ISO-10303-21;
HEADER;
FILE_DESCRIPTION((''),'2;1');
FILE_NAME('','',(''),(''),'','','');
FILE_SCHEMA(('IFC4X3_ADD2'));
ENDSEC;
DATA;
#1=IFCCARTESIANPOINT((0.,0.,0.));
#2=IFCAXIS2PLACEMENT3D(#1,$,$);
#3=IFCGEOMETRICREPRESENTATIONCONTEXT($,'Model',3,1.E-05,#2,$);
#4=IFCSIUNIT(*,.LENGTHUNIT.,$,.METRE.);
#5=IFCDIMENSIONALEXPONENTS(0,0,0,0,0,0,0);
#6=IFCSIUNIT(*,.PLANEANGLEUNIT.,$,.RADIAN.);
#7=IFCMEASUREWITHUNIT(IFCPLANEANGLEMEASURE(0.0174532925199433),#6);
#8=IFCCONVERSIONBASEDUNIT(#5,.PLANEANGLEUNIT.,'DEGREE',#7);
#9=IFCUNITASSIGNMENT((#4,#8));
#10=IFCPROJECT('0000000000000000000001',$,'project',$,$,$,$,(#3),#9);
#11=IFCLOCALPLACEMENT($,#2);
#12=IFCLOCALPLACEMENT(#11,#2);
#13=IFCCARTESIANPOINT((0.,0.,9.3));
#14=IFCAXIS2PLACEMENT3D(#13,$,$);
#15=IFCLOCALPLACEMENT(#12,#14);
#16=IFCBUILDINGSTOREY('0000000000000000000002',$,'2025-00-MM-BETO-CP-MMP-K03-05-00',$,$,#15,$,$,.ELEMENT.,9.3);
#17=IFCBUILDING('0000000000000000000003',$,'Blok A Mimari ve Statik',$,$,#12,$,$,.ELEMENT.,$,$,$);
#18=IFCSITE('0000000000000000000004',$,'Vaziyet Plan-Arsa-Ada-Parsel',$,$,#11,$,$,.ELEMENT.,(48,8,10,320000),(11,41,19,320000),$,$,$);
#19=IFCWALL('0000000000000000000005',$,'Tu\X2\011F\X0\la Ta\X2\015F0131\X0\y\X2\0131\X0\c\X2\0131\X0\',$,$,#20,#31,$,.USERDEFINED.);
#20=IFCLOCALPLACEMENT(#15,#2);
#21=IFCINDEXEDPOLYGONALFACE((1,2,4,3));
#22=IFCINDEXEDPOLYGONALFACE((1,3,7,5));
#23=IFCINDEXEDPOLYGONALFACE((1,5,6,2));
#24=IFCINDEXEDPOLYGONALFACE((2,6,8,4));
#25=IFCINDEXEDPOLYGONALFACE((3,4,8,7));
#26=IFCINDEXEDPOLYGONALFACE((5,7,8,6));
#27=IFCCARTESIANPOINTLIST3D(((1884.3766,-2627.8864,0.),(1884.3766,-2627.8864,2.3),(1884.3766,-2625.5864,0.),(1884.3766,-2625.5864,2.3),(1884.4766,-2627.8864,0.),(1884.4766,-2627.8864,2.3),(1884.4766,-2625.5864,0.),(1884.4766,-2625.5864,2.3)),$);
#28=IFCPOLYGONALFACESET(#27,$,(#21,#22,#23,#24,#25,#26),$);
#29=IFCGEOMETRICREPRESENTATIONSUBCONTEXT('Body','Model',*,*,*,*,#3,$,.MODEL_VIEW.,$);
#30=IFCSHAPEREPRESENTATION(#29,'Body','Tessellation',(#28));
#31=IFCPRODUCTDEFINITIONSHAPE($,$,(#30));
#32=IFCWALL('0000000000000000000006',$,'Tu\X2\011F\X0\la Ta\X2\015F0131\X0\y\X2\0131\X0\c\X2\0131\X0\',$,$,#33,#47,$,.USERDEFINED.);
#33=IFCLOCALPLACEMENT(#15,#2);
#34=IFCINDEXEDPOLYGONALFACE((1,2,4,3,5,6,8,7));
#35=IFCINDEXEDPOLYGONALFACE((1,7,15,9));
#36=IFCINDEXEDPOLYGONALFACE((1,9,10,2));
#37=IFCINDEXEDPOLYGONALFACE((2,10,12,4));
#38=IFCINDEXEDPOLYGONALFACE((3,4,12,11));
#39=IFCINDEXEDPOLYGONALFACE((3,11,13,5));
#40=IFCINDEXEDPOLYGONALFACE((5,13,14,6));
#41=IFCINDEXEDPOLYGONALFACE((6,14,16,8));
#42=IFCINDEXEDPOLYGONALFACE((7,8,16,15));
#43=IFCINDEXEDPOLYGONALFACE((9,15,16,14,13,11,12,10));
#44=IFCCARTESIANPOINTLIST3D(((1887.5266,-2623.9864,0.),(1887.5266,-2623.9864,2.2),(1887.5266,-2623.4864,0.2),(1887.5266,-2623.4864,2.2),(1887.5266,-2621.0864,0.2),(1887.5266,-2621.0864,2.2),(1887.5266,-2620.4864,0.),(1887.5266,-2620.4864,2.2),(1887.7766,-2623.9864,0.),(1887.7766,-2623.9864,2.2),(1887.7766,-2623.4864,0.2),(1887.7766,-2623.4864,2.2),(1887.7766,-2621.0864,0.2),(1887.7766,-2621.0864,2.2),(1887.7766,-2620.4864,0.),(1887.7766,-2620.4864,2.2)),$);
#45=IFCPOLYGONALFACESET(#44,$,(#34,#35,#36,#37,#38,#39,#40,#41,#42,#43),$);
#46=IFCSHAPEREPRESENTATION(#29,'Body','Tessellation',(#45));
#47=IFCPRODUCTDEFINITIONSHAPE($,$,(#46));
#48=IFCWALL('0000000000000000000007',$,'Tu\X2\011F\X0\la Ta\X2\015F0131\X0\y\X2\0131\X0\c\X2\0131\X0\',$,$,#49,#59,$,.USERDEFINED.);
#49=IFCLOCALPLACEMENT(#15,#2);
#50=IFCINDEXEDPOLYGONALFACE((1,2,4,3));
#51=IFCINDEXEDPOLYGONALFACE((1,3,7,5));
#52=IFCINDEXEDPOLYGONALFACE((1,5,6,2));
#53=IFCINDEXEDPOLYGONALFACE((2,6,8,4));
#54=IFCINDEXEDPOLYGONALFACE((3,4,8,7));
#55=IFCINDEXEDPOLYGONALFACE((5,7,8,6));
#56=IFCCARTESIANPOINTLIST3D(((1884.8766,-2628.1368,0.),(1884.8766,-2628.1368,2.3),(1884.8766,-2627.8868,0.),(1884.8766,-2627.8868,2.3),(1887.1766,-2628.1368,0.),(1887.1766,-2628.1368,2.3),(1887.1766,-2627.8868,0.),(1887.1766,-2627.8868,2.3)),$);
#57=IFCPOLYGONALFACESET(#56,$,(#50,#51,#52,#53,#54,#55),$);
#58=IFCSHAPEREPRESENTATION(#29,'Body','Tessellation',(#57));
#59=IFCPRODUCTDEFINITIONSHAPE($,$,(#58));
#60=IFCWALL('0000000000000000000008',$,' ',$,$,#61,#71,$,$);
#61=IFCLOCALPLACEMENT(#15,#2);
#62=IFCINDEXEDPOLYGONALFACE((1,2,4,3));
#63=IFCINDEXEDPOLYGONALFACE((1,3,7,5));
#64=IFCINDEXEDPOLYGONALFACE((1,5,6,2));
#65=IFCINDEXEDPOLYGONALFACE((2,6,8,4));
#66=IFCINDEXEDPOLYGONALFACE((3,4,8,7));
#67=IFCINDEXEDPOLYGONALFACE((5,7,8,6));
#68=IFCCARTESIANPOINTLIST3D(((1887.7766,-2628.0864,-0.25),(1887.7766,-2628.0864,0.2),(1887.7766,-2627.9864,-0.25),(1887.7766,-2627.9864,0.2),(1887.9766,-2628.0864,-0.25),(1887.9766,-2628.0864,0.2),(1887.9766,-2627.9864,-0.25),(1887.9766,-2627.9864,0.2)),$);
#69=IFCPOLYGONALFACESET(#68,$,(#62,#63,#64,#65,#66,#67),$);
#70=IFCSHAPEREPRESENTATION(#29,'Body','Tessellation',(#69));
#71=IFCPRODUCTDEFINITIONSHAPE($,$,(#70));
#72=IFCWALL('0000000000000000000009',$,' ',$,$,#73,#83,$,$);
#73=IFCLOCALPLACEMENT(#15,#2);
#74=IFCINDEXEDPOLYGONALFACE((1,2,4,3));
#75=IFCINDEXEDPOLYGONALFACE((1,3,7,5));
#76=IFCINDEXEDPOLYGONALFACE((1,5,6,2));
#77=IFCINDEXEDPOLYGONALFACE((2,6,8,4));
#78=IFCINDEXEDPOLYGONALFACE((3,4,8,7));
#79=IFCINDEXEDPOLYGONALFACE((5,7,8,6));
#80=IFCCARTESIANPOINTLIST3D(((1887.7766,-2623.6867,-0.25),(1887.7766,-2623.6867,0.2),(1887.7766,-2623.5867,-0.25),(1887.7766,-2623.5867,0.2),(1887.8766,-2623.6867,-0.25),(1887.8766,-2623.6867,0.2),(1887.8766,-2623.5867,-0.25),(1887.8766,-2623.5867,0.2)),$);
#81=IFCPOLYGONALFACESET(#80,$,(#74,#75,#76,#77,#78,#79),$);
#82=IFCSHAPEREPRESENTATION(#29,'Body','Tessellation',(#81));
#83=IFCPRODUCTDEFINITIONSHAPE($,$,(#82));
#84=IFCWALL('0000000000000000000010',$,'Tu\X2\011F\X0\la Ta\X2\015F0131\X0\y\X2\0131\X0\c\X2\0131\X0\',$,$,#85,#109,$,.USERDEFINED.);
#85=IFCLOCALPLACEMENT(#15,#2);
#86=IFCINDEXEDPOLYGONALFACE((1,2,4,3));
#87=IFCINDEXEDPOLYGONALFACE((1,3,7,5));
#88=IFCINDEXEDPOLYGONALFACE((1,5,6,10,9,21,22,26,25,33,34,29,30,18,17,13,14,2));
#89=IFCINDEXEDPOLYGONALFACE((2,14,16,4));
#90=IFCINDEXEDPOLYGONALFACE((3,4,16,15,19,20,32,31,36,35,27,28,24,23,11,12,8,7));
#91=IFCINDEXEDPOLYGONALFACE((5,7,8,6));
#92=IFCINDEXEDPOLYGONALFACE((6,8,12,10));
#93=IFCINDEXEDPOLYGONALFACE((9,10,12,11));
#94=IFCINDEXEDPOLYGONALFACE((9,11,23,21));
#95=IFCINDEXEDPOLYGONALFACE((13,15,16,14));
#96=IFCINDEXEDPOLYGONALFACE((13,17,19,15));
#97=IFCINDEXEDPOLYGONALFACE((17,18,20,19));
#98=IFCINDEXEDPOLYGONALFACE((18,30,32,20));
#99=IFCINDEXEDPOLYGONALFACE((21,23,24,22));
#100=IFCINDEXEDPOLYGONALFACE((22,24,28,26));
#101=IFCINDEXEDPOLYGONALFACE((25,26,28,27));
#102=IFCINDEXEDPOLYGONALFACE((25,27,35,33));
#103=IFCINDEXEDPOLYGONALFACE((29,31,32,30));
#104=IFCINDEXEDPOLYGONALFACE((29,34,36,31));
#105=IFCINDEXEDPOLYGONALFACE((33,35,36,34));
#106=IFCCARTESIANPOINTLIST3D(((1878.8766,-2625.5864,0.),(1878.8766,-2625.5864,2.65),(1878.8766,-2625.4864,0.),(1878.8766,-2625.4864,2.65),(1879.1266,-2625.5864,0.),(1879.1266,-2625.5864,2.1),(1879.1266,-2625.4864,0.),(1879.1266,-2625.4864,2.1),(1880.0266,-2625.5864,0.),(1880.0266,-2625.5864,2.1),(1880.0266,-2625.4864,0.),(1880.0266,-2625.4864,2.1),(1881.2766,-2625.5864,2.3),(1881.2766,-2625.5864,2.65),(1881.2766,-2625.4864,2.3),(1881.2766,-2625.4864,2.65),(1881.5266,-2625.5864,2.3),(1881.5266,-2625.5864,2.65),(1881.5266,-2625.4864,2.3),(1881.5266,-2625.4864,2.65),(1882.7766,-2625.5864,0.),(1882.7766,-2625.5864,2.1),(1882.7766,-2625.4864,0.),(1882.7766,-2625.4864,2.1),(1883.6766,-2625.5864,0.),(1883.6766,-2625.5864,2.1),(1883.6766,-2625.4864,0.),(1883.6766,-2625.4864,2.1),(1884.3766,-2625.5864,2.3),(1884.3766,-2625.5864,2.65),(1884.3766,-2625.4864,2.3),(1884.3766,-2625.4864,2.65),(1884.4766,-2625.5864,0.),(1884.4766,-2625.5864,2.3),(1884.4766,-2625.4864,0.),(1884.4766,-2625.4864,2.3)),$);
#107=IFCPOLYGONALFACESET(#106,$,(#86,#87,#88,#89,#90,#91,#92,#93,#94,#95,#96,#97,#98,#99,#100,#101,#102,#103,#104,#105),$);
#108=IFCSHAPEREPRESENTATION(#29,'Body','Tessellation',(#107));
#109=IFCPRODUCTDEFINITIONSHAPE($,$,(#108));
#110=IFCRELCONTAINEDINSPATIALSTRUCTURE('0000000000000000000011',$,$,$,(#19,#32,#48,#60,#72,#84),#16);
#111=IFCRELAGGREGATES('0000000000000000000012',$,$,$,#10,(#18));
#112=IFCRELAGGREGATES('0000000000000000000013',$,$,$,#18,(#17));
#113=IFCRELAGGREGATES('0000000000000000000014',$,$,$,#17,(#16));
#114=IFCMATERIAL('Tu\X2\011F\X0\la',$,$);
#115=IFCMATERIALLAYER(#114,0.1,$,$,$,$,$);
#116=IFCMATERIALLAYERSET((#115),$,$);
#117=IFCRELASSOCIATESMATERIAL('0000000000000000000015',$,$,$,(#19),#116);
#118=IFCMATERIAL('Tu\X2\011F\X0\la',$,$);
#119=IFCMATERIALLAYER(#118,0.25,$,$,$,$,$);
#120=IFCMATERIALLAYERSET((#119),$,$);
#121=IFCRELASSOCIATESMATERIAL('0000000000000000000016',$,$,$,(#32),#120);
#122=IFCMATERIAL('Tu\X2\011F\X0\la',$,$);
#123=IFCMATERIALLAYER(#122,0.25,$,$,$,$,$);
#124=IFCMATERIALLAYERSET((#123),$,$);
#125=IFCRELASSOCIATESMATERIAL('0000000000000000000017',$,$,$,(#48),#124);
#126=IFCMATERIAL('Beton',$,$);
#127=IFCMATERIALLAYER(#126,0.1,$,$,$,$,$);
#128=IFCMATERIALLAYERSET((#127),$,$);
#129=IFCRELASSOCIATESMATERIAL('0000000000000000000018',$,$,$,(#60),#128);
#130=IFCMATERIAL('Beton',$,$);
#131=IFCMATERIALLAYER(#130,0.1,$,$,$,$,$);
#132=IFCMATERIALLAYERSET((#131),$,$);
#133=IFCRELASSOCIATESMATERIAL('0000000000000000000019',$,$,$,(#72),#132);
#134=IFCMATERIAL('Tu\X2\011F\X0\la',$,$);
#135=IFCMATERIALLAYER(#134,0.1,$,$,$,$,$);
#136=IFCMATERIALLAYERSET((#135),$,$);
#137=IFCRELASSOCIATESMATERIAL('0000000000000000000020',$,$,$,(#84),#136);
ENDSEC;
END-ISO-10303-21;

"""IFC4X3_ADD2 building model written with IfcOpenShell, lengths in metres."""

from ifc_helpers import new_model, entity, si_unit, converted_unit, frame, frame_2d, origin, origin_with_axes, place, context, subcontext, project, spatial, polyline, rectangle, outline, extrude, clip, bounded_halfspace, material, layer, layer_set, layer_usage, element, save


model = new_model("IFC4X3_ADD2")

# Units and contexts
model_context = context("Model", 3, precision=1e-05, world=origin())
body_context = subcontext(model_context, "Body", "Model", "MODEL_VIEW")
ifc_project = project(units=[si_unit("LENGTHUNIT", "METRE"), converted_unit("PLANEANGLEUNIT", "DEGREE", entity("IfcPlaneAngleMeasure", 0.0174532925199433), si_unit("PLANEANGLEUNIT", "RADIAN"), dimensions=[0, 0, 0, 0, 0, 0, 0])], contexts=[model_context])

# Site, building, storey
site_placement = place(None, origin())
site = spatial("IfcSite", under=ifc_project, at=site_placement, Name="Vaziyet Plan-Arsa-Ada-Parsel", CompositionType="ELEMENT", RefLatitude=(48, 8, 10, 320000), RefLongitude=(11, 41, 19, 320000))
building_placement = place(site_placement, origin())
building = spatial("IfcBuilding", under=site, at=building_placement, Name="Blok A Mimari ve Statik", CompositionType="ELEMENT")
storey_placement = place(building_placement, frame((0.0, 0.0, 9.3)))
storey = spatial("IfcBuildingStorey", under=building, at=storey_placement, Name="2025-00-MM-BETO-CP-MMP-K03-05-00", CompositionType="ELEMENT", Elevation=9.3)

# Wall
ifc_material_1 = material(Name="Tuğla")
ifc_layer_1 = layer(ifc_material_1, 0.1)
ifc_layer_set_1 = layer_set([ifc_layer_1])
ifc_layer_usage_1 = layer_usage(ifc_layer_set_1, "AXIS2", "POSITIVE", 0.0)
wall_1_placement = place(storey_placement, frame((1884.4766, -2627.8864, 0.0), z_axis=(0.0, 0.0, 1.0), x_axis=(0.0, 1.0, 0.0)))
element("IfcWall", 1, at=wall_1_placement, inside=storey, material=ifc_layer_usage_1, Name="Tuğla Taşıyıcı", PredefinedType="USERDEFINED", context=body_context, shape_type="SweptSolid", body=[
    extrude(rectangle(XDim=2.3, YDim=0.1, at=frame_2d((1.15, 0.05), x_axis=(1.0, 0.0))), origin_with_axes(), (0.0, 0.0, 1.0), 2.3),
])

# Wall, opening
ifc_material_2 = material(Name="Tuğla")
ifc_layer_2 = layer(ifc_material_2, 0.25)
ifc_layer_set_2 = layer_set([ifc_layer_2])
ifc_layer_usage_2 = layer_usage(ifc_layer_set_2, "AXIS2", "POSITIVE", 0.0)
wall_2_placement = place(storey_placement, frame((1887.7766, -2623.9864, 0.0), z_axis=(0.0, 0.0, 1.0), x_axis=(0.0, 1.0, 0.0)))
wall_2 = element("IfcWall", 2, at=wall_2_placement, inside=storey, material=ifc_layer_usage_2, Name="Tuğla Taşıyıcı", PredefinedType="USERDEFINED", context=body_context, shape_type="SweptSolid", body=[
    extrude(rectangle(XDim=3.5, YDim=0.25, at=frame_2d((1.75, 0.125), x_axis=(1.0, 0.0))), origin_with_axes(), (0.0, 0.0, 1.0), 2.2),
])
opening_1_placement = place(wall_2_placement, frame((0.5, 0.0, 0.2), z_axis=(0.0, 1.0, 0.0), x_axis=(0.0, 0.0, 1.0)))
element("IfcOpeningElement", 3, at=opening_1_placement, cuts=wall_2, PredefinedType="OPENING", context=body_context, shape_type="SweptSolid", body=[
    extrude(outline(polyline([(2.1, 2.4), (2.1, 0.0), (0.0, 0.0), (0.0, 2.4), (2.1, 2.4)])), origin_with_axes(), (0.0, 0.0, 1.0), 0.25),
])

# Walls
ifc_material_3 = material(Name="Tuğla")
ifc_layer_3 = layer(ifc_material_3, 0.25)
ifc_layer_set_3 = layer_set([ifc_layer_3])
ifc_layer_usage_3 = layer_usage(ifc_layer_set_3, "AXIS2", "POSITIVE", 0.0)
wall_3_placement = place(storey_placement, frame((1887.1766, -2627.8868, 0.0), z_axis=(0.0, 0.0, 1.0), x_axis=(-1.0, 0.0, 0.0)))
element("IfcWall", 4, at=wall_3_placement, inside=storey, material=ifc_layer_usage_3, Name="Tuğla Taşıyıcı", PredefinedType="USERDEFINED", context=body_context, shape_type="SweptSolid", body=[
    extrude(rectangle(XDim=2.3, YDim=0.25, at=frame_2d((1.15, 0.125), x_axis=(1.0, 0.0))), origin_with_axes(), (0.0, 0.0, 1.0), 2.3),
])
ifc_material_4 = material(Name="Beton")
ifc_layer_4 = layer(ifc_material_4, 0.1)
ifc_layer_set_4 = layer_set([ifc_layer_4])
ifc_layer_usage_4 = layer_usage(ifc_layer_set_4, "AXIS2", "POSITIVE", 0.0)
wall_4_placement = place(storey_placement, frame((1887.9766, -2627.9864, -0.25), z_axis=(0.0, 0.0, 1.0), x_axis=(-1.0, 0.0, 0.0)))
element("IfcWall", 5, at=wall_4_placement, inside=storey, material=ifc_layer_usage_4, Name=" ", context=body_context, shape_type="SweptSolid", body=[
    extrude(rectangle(XDim=0.2, YDim=0.1, at=frame_2d((0.1, 0.05), x_axis=(1.0, 0.0))), origin_with_axes(), (0.0, 0.0, 1.0), 0.45),
])
ifc_material_5 = material(Name="Beton")
ifc_layer_5 = layer(ifc_material_5, 0.1)
ifc_layer_set_5 = layer_set([ifc_layer_5])
ifc_layer_usage_5 = layer_usage(ifc_layer_set_5, "AXIS2", "POSITIVE", 0.0)
wall_5_placement = place(storey_placement, frame((1887.7766, -2623.6867, -0.25)))
element("IfcWall", 6, at=wall_5_placement, inside=storey, material=ifc_layer_usage_5, Name=" ", context=body_context, shape_type="SweptSolid", body=[
    extrude(rectangle(XDim=0.1, YDim=0.1, at=frame_2d((0.05, 0.05), x_axis=(1.0, 0.0))), origin_with_axes(), (0.0, 0.0, 1.0), 0.45),
])

# Wall, openings
ifc_material_6 = material(Name="Tuğla")
ifc_layer_6 = layer(ifc_material_6, 0.1)
ifc_layer_set_6 = layer_set([ifc_layer_6])
ifc_layer_usage_6 = layer_usage(ifc_layer_set_6, "AXIS2", "POSITIVE", 0.0)
wall_6_placement = place(storey_placement, frame((1884.4766, -2625.4864, 0.0), z_axis=(0.0, 0.0, 1.0), x_axis=(-1.0, 0.0, 0.0)))
wall_6 = element("IfcWall", 7, at=wall_6_placement, inside=storey, material=ifc_layer_usage_6, Name="Tuğla Taşıyıcı", PredefinedType="USERDEFINED", context=body_context, shape_type="Clipping", body=[
    clip(clip(extrude(rectangle(XDim=5.6, YDim=0.1, at=frame_2d((2.8, 0.05), x_axis=(1.0, 0.0))), origin_with_axes(), (0.0, 0.0, 1.0), 2.65), bounded_halfspace(frame((0.05, 0.05, 2.3), z_axis=(0.0, 0.0, -1.0), x_axis=(0.0, -1.0, 0.0)), True, origin_with_axes(), polyline([(0.0, 0.1), (0.0, 0.0), (0.1, 0.0), (0.1, 0.1), (0.0, 0.1)]))), bounded_halfspace(frame((3.075, 0.05, 2.3), z_axis=(0.0, 0.0, -1.0), x_axis=(0.0, -1.0, 0.0)), True, origin_with_axes(), polyline([(2.95, 0.1), (2.95, 0.0), (3.2, 0.0), (3.2, 0.1), (2.95, 0.1)]))),
])
opening_2_placement = place(wall_6_placement, frame((0.8, 0.0, 0.0), z_axis=(0.0, 1.0, 0.0), x_axis=(0.0, 0.0, 1.0)))
element("IfcOpeningElement", 8, at=opening_2_placement, cuts=wall_6, PredefinedType="OPENING", context=body_context, shape_type="SweptSolid", body=[
    extrude(outline(polyline([(2.1, 0.9), (2.1, 0.0), (0.0, 0.0), (0.0, 0.9), (2.1, 0.9)])), origin_with_axes(), (0.0, 0.0, 1.0), 0.1),
])
opening_3_placement = place(wall_6_placement, frame((4.45, 0.0, 0.0), z_axis=(0.0, 1.0, 0.0), x_axis=(0.0, 0.0, 1.0)))
element("IfcOpeningElement", 9, at=opening_3_placement, cuts=wall_6, PredefinedType="OPENING", context=body_context, shape_type="SweptSolid", body=[
    extrude(outline(polyline([(2.1, 0.9), (2.1, 0.0), (0.0, 0.0), (0.0, 0.9), (2.1, 0.9)])), origin_with_axes(), (0.0, 0.0, 1.0), 0.1),
])

save(model, "model.ifc")
